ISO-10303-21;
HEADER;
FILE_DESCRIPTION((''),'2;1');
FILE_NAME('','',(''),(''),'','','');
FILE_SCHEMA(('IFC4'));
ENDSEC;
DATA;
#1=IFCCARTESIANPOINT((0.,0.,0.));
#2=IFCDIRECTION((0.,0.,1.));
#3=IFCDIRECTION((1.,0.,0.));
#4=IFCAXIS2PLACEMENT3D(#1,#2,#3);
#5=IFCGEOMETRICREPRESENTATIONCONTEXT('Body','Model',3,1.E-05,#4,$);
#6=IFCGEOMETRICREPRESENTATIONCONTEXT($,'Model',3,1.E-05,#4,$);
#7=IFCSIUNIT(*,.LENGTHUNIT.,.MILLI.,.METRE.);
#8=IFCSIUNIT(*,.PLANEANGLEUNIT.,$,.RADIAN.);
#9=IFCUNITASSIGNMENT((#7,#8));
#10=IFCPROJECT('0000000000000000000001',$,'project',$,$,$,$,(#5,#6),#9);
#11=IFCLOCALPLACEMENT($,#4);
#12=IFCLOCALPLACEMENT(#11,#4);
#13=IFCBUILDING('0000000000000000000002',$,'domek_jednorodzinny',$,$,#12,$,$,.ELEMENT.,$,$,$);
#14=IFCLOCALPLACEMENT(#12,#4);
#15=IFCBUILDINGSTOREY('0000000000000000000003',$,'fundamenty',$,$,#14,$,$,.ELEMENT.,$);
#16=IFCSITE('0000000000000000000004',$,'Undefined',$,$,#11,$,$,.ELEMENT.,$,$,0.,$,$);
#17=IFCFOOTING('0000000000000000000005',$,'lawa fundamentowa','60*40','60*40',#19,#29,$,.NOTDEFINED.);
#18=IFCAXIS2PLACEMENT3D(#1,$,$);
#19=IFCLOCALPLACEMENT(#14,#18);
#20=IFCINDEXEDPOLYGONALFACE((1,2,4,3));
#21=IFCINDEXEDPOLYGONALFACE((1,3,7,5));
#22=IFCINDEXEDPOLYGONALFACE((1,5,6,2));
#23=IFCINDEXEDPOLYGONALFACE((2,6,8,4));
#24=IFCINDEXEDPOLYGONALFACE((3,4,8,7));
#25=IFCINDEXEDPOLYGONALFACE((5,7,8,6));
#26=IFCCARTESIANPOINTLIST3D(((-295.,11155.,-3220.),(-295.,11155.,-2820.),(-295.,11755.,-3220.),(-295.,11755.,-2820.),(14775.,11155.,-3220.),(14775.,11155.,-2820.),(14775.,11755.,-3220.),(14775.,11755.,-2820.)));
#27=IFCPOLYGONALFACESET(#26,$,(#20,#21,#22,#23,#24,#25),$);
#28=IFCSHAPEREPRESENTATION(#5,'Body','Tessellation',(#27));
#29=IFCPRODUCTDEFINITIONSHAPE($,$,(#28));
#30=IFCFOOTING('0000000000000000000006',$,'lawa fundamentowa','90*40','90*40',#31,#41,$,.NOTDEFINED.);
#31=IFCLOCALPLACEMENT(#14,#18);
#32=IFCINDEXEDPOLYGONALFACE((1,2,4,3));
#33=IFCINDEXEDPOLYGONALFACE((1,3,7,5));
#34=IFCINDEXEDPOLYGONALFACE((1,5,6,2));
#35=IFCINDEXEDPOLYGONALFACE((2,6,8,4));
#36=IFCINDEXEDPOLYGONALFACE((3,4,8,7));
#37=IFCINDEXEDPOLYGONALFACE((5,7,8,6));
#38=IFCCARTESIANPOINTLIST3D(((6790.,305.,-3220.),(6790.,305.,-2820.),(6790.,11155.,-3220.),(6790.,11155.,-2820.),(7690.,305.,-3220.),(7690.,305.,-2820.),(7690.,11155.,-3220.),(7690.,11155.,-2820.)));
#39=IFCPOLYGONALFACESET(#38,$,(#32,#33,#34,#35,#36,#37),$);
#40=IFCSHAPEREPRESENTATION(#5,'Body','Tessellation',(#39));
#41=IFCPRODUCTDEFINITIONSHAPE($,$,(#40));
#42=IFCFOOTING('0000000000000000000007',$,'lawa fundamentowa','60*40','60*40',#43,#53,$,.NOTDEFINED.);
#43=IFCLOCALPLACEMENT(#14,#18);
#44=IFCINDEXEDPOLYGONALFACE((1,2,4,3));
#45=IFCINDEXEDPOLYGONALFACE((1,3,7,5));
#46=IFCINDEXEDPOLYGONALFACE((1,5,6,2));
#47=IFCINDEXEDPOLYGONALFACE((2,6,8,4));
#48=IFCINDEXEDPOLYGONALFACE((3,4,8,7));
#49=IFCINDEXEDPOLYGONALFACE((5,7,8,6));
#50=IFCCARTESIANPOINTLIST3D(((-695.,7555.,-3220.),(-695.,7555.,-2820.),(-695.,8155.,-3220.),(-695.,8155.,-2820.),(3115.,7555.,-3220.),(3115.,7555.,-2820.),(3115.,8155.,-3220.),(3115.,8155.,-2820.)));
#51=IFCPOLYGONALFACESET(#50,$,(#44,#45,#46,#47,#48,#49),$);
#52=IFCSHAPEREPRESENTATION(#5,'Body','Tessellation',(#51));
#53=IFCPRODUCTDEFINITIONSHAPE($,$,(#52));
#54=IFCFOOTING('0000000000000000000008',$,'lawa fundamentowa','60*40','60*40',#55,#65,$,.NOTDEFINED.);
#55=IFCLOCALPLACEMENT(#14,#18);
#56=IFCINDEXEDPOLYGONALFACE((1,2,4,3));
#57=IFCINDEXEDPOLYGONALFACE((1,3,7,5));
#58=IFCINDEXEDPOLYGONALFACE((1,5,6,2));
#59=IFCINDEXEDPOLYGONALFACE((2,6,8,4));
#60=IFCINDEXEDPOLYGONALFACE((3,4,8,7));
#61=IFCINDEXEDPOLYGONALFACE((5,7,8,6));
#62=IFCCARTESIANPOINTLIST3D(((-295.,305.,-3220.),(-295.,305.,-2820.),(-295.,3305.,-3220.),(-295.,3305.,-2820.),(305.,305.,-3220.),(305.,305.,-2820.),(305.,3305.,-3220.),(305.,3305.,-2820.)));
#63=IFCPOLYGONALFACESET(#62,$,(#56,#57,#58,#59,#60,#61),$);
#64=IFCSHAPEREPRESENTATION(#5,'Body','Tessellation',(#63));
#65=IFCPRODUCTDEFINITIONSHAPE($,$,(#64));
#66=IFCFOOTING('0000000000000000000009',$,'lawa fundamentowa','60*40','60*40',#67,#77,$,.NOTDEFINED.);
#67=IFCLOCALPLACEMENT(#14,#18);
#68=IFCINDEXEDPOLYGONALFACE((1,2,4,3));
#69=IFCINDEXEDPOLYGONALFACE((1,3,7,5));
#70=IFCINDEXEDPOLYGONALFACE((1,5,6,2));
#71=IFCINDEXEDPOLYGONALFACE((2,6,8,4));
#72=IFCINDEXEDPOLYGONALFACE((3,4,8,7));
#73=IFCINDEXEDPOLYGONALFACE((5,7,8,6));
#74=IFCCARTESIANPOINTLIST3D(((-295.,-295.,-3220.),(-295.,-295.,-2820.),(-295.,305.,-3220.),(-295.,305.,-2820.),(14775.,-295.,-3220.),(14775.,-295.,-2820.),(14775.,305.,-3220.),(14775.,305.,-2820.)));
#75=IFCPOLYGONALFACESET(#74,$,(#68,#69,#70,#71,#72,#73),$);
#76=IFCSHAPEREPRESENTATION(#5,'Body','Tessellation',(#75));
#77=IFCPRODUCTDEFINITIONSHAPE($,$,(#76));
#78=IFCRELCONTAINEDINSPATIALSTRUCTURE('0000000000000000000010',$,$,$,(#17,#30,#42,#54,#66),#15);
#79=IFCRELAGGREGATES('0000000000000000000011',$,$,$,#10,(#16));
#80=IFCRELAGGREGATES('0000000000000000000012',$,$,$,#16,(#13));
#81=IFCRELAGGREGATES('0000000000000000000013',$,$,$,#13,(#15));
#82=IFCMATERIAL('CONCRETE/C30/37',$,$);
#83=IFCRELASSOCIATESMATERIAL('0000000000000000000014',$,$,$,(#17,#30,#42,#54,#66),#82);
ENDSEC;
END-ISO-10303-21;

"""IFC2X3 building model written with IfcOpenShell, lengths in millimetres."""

from ifc_helpers import new_model, si_unit, frame, origin_with_axes, origin_2d_with_axis, place, context, project, spatial, rectangle, extrude, material, element, save


model = new_model("IFC2X3")

# Units and contexts
model_context_1 = context("Model", 3, precision=1e-05, world=origin_with_axes(), identifier="Body")
model_context_2 = context("Model", 3, precision=1e-05, world=origin_with_axes())
ifc_project = project(units=[si_unit("LENGTHUNIT", "METRE", prefix="MILLI"), si_unit("PLANEANGLEUNIT", "RADIAN")], contexts=[model_context_1, model_context_2])

# Site, building, storey
site_placement = place(None, origin_with_axes())
site = spatial("IfcSite", under=ifc_project, at=site_placement, Name="Undefined", CompositionType="ELEMENT", RefElevation=0.0)
building_placement = place(site_placement, origin_with_axes())
building = spatial("IfcBuilding", under=site, at=building_placement, Name="domek_jednorodzinny", CompositionType="ELEMENT")
storey_placement = place(building_placement, origin_with_axes())
storey = spatial("IfcBuildingStorey", under=building, at=storey_placement, Name="fundamenty", CompositionType="ELEMENT")

# Shared definitions
ifc_material = material(Name="CONCRETE/C30/37")

# Footings
footing_1_placement = place(storey_placement, frame((-295.0, 11455.0, -3020.0), z_axis=(0.0, 0.0, 1.0), x_axis=(1.0, 0.0, 0.0)))
element("IfcFooting", 1, at=footing_1_placement, inside=storey, material=ifc_material, Name="lawa fundamentowa", Description="60*40", ObjectType="60*40", PredefinedType="NOTDEFINED", context=model_context_1, shape_type="SweptSolid", body=[
    extrude(rectangle(XDim=600.0, YDim=400.0, at=origin_2d_with_axis()), frame((15070.0, 0.0, 0.0), z_axis=(-1.0, 0.0, 0.0), x_axis=(0.0, -1.0, 0.0)), (0.0, 0.0, 1.0), 15070.0),
])
footing_2_placement = place(storey_placement, frame((7240.0, 305.0, -3020.0), z_axis=(0.0, 0.0, 1.0), x_axis=(0.0, 1.0, 0.0)))
element("IfcFooting", 2, at=footing_2_placement, inside=storey, material=ifc_material, Name="lawa fundamentowa", Description="90*40", ObjectType="90*40", PredefinedType="NOTDEFINED", context=model_context_1, shape_type="SweptSolid", body=[
    extrude(rectangle(XDim=900.0, YDim=400.0, at=origin_2d_with_axis()), frame((10850.0, 0.0, 0.0), z_axis=(-1.0, 0.0, 0.0), x_axis=(0.0, -1.0, 0.0)), (0.0, 0.0, 1.0), 10850.0),
])
footing_3_placement = place(storey_placement, frame((-695.0, 7855.0, -3020.0), z_axis=(0.0, 0.0, 1.0), x_axis=(1.0, 0.0, 0.0)))
element("IfcFooting", 3, at=footing_3_placement, inside=storey, material=ifc_material, Name="lawa fundamentowa", Description="60*40", ObjectType="60*40", PredefinedType="NOTDEFINED", context=model_context_1, shape_type="SweptSolid", body=[
    extrude(rectangle(XDim=600.0, YDim=400.0, at=origin_2d_with_axis()), frame((3810.0, 0.0, 0.0), z_axis=(-1.0, 0.0, 0.0), x_axis=(0.0, -1.0, 0.0)), (0.0, 0.0, 1.0), 3810.0),
])
footing_4_placement = place(storey_placement, frame((5.0, 305.0, -3020.0), z_axis=(0.0, 0.0, 1.0), x_axis=(0.0, 1.0, 0.0)))
element("IfcFooting", 4, at=footing_4_placement, inside=storey, material=ifc_material, Name="lawa fundamentowa", Description="60*40", ObjectType="60*40", PredefinedType="NOTDEFINED", context=model_context_1, shape_type="SweptSolid", body=[
    extrude(rectangle(XDim=600.0, YDim=400.0, at=origin_2d_with_axis()), frame((3000.0, 0.0, 0.0), z_axis=(-1.0, 0.0, 0.0), x_axis=(0.0, -1.0, 0.0)), (0.0, 0.0, 1.0), 3000.0),
])
footing_5_placement = place(storey_placement, frame((-295.0, 5.0, -3020.0), z_axis=(0.0, 0.0, 1.0), x_axis=(1.0, 0.0, 0.0)))
element("IfcFooting", 5, at=footing_5_placement, inside=storey, material=ifc_material, Name="lawa fundamentowa", Description="60*40", ObjectType="60*40", PredefinedType="NOTDEFINED", context=model_context_1, shape_type="SweptSolid", body=[
    extrude(rectangle(XDim=600.0, YDim=400.0, at=origin_2d_with_axis()), frame((15070.0, 0.0, 0.0), z_axis=(-1.0, 0.0, 0.0), x_axis=(0.0, -1.0, 0.0)), (0.0, 0.0, 1.0), 15070.0),
])

save(model, "model.ifc")
